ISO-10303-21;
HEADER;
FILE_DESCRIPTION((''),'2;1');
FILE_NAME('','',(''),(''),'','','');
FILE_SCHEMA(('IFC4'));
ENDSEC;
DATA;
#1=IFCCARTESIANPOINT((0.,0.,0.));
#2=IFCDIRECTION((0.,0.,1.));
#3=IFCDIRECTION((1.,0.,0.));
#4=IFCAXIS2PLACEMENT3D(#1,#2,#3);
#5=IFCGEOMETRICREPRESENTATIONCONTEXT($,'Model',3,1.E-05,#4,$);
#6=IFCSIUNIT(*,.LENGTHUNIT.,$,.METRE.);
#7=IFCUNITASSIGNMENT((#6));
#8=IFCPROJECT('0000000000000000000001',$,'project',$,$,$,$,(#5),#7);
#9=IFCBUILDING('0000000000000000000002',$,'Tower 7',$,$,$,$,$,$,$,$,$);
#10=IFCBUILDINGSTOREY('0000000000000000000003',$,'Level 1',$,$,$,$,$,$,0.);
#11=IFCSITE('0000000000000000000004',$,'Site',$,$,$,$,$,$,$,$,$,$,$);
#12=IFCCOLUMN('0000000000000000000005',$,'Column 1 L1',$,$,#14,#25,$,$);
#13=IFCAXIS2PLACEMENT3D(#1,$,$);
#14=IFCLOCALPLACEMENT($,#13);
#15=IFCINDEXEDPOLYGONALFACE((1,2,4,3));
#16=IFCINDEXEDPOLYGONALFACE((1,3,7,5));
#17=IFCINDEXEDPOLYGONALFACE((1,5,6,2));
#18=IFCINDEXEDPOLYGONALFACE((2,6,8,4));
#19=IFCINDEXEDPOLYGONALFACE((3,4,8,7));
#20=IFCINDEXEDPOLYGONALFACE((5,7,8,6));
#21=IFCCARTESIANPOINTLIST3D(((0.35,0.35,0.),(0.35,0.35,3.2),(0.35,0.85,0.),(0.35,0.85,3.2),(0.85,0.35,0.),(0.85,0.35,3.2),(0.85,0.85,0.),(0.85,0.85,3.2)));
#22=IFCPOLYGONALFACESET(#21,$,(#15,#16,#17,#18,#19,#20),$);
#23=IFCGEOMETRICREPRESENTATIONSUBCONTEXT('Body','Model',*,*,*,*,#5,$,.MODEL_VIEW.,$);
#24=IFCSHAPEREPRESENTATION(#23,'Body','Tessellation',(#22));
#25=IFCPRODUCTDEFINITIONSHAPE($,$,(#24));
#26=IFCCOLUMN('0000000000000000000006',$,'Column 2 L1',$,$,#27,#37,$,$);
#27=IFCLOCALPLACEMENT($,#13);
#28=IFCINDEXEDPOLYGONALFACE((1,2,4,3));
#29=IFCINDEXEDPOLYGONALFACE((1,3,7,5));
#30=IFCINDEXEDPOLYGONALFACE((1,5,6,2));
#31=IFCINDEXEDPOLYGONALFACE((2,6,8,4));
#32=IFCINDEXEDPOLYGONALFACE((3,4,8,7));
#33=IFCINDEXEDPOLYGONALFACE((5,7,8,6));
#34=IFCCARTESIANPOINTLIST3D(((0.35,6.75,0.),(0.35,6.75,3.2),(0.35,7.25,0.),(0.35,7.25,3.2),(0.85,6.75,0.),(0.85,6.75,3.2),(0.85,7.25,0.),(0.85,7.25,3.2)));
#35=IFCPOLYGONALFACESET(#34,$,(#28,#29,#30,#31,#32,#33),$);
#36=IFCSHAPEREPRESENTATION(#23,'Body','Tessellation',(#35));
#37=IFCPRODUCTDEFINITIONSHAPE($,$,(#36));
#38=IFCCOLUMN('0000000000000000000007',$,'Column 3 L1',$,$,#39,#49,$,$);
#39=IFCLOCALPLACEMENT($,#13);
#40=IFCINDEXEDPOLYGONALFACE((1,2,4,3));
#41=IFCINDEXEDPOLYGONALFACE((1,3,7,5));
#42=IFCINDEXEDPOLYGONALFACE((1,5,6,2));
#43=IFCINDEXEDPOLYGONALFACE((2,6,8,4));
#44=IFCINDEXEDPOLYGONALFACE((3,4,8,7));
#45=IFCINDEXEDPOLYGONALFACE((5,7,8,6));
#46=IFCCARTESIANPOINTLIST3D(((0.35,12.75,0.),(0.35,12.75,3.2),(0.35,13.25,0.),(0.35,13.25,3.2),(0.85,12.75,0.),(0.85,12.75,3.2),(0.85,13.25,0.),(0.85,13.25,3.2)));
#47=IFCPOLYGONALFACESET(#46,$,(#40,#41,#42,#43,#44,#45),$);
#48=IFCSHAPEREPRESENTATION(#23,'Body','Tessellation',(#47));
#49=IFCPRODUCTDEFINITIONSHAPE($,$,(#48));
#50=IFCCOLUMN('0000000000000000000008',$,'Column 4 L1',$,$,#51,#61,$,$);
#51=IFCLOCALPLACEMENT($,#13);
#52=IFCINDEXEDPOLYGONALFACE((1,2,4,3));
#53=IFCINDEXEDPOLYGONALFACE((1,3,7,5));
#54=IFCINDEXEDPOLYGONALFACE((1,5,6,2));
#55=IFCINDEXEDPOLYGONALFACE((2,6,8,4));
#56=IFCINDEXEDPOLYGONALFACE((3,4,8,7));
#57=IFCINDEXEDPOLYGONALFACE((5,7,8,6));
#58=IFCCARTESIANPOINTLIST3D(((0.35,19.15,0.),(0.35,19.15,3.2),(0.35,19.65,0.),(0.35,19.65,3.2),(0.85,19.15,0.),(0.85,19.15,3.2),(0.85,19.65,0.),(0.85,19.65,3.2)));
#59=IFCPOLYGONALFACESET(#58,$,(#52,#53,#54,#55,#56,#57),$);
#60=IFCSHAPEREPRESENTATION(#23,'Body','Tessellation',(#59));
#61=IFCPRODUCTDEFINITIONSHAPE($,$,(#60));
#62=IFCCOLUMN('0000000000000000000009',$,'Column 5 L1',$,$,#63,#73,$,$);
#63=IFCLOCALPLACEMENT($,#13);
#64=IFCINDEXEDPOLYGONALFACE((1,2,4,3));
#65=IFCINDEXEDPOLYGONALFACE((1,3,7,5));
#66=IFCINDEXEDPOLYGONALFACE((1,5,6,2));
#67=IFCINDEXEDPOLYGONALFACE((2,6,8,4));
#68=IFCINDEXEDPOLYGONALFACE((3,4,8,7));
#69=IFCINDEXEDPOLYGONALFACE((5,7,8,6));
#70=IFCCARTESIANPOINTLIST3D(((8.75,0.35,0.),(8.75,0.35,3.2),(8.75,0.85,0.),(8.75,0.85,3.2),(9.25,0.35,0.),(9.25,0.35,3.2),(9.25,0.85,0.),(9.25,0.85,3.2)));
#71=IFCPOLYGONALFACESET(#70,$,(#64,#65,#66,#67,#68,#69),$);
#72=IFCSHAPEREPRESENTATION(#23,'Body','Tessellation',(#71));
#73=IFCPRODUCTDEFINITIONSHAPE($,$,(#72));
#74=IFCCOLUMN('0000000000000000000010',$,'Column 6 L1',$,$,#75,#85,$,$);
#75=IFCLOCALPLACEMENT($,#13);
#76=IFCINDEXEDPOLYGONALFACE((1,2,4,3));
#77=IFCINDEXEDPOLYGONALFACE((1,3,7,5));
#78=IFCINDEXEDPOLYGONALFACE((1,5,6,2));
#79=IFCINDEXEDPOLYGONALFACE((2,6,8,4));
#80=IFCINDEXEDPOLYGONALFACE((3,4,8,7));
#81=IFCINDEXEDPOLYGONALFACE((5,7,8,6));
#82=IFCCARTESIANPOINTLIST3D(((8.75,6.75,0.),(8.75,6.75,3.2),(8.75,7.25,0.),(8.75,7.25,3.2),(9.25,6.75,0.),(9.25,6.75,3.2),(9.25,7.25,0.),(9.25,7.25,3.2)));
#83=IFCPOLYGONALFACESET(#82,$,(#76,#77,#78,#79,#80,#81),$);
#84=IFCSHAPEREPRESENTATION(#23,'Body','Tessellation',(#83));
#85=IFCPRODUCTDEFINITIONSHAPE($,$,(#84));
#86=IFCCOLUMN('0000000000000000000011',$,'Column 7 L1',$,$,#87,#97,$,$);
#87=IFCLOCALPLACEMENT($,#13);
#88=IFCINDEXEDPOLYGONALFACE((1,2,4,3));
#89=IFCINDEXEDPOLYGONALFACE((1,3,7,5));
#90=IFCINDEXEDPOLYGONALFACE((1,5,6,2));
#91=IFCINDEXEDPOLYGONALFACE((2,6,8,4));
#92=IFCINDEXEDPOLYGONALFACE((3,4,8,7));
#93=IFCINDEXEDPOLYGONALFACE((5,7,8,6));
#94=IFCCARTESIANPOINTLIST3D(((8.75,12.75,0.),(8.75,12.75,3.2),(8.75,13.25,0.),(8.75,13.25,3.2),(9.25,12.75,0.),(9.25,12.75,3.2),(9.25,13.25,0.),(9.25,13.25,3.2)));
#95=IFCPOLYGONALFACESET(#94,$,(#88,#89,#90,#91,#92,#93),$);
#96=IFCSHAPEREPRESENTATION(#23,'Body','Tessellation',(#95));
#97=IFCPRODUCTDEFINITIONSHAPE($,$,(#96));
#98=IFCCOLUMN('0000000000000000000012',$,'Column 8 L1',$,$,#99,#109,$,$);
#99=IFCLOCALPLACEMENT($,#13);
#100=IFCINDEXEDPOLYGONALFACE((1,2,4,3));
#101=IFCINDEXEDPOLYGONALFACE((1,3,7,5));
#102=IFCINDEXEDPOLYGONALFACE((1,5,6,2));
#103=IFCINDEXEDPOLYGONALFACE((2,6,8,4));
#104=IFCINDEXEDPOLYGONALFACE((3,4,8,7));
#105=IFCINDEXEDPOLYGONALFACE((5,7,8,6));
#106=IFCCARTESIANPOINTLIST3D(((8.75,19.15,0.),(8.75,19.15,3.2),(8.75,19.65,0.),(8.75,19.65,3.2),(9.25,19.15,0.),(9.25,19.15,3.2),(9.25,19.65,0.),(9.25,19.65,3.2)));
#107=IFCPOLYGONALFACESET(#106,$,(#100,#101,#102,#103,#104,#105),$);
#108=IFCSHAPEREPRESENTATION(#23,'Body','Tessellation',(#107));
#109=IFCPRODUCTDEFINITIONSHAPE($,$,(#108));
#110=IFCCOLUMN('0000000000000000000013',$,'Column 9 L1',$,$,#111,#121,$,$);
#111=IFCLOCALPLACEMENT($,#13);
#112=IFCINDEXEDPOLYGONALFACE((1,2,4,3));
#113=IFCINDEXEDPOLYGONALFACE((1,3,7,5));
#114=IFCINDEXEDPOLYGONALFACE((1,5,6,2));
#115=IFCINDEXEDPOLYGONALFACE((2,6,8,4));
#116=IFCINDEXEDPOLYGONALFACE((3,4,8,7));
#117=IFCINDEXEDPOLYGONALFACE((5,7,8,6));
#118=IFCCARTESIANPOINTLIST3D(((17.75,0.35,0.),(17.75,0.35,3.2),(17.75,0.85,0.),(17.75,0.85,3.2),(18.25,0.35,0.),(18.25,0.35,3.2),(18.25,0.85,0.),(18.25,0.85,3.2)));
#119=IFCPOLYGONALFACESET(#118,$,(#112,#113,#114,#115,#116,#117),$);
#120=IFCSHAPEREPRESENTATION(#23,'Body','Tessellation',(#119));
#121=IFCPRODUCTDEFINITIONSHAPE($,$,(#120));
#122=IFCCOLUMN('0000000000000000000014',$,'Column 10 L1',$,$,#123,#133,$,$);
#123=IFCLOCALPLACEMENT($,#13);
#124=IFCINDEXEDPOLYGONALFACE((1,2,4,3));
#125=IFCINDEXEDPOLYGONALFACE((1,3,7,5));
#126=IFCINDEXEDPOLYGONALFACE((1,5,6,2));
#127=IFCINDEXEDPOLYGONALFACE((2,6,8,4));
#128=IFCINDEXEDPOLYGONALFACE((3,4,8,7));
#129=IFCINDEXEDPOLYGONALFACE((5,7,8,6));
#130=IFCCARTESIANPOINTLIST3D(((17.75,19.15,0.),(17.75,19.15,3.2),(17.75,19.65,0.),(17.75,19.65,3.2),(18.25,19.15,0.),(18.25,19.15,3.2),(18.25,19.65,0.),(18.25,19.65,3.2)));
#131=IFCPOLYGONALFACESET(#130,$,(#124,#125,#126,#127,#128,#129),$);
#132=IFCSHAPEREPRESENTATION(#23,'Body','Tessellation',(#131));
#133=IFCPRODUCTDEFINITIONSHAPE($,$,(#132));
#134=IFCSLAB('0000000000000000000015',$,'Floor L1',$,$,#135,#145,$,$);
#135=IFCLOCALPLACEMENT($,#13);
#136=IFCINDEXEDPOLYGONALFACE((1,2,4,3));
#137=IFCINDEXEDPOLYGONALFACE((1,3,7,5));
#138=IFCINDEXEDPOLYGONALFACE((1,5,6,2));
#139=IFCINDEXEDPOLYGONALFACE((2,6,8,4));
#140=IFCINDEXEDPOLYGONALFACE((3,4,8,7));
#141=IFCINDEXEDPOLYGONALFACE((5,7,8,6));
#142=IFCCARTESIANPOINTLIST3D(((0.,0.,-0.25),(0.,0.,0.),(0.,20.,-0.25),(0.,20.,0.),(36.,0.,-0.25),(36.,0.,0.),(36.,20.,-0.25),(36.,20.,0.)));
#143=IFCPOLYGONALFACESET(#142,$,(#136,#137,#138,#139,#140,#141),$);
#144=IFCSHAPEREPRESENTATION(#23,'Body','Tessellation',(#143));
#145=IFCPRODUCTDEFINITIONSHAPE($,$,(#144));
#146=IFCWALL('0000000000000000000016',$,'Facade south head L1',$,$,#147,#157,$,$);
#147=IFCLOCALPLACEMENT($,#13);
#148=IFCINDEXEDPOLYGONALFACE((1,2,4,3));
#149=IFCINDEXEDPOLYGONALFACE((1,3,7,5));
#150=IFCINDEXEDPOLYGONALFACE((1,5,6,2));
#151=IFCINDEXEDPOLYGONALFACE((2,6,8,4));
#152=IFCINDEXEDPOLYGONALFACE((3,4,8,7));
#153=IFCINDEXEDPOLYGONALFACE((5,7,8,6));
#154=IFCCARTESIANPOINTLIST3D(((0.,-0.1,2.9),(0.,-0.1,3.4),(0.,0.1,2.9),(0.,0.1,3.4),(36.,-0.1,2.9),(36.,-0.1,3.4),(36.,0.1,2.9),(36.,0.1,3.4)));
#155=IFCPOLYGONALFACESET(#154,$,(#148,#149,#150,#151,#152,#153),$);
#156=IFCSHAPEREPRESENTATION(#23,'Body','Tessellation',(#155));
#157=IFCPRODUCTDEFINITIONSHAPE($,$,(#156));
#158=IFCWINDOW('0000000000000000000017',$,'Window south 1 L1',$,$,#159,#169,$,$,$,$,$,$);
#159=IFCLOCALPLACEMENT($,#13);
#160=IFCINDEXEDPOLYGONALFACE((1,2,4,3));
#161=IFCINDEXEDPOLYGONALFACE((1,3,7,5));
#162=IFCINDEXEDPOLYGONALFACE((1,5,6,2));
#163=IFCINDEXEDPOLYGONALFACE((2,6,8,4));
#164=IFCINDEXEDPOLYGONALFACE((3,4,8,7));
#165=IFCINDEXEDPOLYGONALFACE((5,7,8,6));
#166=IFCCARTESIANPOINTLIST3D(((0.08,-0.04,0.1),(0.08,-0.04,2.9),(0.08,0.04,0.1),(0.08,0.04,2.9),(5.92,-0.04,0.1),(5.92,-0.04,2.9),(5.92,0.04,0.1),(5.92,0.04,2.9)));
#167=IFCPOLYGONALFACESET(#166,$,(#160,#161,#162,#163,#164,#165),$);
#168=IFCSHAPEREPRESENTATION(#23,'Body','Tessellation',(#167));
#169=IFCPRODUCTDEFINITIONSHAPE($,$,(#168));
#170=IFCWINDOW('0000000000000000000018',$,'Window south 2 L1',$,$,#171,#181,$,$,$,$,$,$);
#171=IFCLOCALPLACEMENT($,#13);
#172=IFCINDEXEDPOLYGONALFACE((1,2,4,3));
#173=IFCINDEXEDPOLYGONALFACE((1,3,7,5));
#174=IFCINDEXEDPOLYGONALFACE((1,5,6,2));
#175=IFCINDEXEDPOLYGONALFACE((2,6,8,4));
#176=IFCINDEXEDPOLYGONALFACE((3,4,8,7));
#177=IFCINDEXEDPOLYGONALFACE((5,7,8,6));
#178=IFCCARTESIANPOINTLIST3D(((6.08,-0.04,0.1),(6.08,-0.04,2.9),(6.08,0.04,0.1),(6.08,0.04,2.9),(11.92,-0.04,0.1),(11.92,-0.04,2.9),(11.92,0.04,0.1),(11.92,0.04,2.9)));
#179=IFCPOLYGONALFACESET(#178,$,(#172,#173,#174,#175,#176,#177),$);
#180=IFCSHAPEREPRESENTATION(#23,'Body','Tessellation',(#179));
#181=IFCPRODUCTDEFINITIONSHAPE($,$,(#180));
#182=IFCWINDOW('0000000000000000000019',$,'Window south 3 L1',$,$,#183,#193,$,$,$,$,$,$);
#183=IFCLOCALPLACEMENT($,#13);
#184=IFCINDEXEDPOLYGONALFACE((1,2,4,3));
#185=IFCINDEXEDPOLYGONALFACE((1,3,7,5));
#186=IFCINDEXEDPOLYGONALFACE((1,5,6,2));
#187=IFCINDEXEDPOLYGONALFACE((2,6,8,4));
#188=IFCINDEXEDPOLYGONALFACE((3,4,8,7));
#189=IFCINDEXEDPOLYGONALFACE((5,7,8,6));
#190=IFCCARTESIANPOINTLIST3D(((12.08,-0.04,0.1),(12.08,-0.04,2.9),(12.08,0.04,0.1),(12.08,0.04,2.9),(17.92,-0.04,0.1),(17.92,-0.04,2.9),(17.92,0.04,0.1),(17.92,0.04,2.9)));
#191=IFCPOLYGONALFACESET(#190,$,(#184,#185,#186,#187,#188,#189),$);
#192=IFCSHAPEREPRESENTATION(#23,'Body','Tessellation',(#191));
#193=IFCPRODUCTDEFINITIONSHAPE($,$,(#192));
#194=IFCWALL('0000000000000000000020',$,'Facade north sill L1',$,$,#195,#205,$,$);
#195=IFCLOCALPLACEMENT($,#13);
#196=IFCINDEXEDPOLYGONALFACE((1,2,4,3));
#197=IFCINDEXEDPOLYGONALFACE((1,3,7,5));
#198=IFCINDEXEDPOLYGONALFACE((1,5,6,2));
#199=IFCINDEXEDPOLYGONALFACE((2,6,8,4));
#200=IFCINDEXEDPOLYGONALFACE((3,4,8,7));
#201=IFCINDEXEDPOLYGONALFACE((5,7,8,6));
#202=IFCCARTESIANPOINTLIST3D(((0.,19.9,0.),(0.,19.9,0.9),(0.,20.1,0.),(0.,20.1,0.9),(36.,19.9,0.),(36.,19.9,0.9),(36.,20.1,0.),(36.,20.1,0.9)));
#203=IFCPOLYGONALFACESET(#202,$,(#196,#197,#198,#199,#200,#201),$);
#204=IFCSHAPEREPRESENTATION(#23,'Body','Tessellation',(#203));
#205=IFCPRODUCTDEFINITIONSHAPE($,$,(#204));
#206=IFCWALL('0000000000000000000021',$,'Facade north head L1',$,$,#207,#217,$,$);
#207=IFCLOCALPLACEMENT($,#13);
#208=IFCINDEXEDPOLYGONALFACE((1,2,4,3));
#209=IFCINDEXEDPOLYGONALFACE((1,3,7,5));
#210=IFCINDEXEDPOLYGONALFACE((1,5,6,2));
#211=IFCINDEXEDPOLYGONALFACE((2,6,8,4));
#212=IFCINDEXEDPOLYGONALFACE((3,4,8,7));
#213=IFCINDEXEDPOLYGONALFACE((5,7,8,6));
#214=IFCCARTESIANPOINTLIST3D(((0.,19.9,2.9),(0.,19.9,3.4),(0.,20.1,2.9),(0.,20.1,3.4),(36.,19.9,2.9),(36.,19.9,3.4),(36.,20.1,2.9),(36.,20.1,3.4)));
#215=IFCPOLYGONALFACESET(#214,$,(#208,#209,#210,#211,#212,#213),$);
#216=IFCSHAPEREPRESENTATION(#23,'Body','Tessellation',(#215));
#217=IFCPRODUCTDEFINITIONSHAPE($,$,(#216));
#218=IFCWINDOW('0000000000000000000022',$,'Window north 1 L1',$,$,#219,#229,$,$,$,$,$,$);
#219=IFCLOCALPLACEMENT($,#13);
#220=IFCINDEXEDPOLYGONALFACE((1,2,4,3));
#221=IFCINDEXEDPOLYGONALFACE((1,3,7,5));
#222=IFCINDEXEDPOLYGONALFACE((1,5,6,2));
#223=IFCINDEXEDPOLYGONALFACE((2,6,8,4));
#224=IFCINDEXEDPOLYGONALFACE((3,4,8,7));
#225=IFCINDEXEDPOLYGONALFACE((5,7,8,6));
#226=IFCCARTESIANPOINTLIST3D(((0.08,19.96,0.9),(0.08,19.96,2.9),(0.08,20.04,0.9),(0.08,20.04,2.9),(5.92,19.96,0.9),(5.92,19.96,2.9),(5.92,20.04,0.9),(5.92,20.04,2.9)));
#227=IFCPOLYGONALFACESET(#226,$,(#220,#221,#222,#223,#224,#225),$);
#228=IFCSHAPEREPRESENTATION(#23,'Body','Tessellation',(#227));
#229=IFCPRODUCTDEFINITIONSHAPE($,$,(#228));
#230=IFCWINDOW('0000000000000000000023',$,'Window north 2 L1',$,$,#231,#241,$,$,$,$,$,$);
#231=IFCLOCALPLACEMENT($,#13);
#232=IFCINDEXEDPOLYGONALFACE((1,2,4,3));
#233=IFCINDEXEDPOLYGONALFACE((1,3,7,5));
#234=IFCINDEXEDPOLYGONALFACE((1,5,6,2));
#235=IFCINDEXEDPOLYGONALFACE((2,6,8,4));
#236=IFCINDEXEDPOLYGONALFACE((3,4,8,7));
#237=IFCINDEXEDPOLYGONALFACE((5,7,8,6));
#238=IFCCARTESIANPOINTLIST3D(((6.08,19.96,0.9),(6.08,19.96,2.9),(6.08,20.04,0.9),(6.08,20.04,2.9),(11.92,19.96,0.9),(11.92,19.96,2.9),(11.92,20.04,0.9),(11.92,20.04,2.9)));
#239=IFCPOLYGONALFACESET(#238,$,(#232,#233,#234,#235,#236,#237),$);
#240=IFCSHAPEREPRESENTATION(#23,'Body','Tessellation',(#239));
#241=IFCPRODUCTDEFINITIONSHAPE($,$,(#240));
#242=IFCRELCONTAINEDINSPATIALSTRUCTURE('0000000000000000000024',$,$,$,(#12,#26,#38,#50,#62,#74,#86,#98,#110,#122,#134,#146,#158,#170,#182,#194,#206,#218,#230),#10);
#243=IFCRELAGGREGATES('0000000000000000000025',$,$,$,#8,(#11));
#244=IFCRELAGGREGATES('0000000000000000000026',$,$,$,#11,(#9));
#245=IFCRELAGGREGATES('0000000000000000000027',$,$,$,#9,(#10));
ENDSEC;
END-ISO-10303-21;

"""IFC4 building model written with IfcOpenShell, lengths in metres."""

from ifc_helpers import new_model, si_unit, frame, origin, origin_with_axes, origin_2d, place, context, subcontext, project, spatial, rectangle, extrude, element, save


model = new_model("IFC4")

# Units and contexts
model_context = context("Model", 3, precision=1e-05, world=origin_with_axes())
body_context = subcontext(model_context, "Body", "Model", "MODEL_VIEW")
ifc_project = project(units=[si_unit("LENGTHUNIT", "METRE")], contexts=[model_context])

# Site, building, storey
site = spatial("IfcSite", under=ifc_project, Name="Site")
building = spatial("IfcBuilding", under=site, Name="Tower 7")
storey = spatial("IfcBuildingStorey", under=building, Name="Level 1", Elevation=0.0)

# Columns
for number, where, z_axis, x_axis, name in (
    (1, (0.6, 0.6, 0.0), (0.0, 0.0, 1.0), (1.0, 0.0, 0.0), "Column 1 L1"),
    (2, (0.6, 7.0, 0.0), (0.0, 0.0, 1.0), (1.0, 0.0, 0.0), "Column 2 L1"),
    (3, (0.6, 13.0, 0.0), (0.0, 0.0, 1.0), (1.0, 0.0, 0.0), "Column 3 L1"),
    (4, (0.6, 19.4, 0.0), (0.0, 0.0, 1.0), (1.0, 0.0, 0.0), "Column 4 L1"),
    (5, (9.0, 0.6, 0.0), (0.0, 0.0, 1.0), (1.0, 0.0, 0.0), "Column 5 L1"),
    (6, (9.0, 7.0, 0.0), (0.0, 0.0, 1.0), (1.0, 0.0, 0.0), "Column 6 L1"),
    (7, (9.0, 13.0, 0.0), (0.0, 0.0, 1.0), (1.0, 0.0, 0.0), "Column 7 L1"),
    (8, (9.0, 19.4, 0.0), (0.0, 0.0, 1.0), (1.0, 0.0, 0.0), "Column 8 L1"),
    (9, (18.0, 0.6, 0.0), (0.0, 0.0, 1.0), (1.0, 0.0, 0.0), "Column 9 L1"),
    (10, (18.0, 19.4, 0.0), (0.0, 0.0, 1.0), (1.0, 0.0, 0.0), "Column 10 L1"),
):
    element("IfcColumn", number, at=place(None, frame(where, z_axis=z_axis, x_axis=x_axis)), inside=storey, Name=name, context=body_context, shape_type="SweptSolid", body=[
        extrude(rectangle(XDim=0.5, YDim=0.5, at=origin_2d()), origin(), (0.0, 0.0, 1.0), 3.2),
    ])

# Slab
slab_placement = place(None, frame((18.0, 10.0, -0.25), z_axis=(0.0, 0.0, 1.0), x_axis=(1.0, 0.0, 0.0)))
element("IfcSlab", 11, at=slab_placement, inside=storey, Name="Floor L1", context=body_context, shape_type="SweptSolid", body=[
    extrude(rectangle(XDim=36.0, YDim=20.0, at=origin_2d()), origin(), (0.0, 0.0, 1.0), 0.25),
])

# Wall
wall_1_placement = place(None, frame((18.0, 0.0, 2.9), z_axis=(0.0, 0.0, 1.0), x_axis=(1.0, 0.0, 0.0)))
element("IfcWall", 12, at=wall_1_placement, inside=storey, Name="Facade south head L1", context=body_context, shape_type="SweptSolid", body=[
    extrude(rectangle(XDim=36.0, YDim=0.2, at=origin_2d()), origin(), (0.0, 0.0, 1.0), 0.5),
])

# Windows
for number, where, z_axis, x_axis, name in (
    (13, (3.0, 0.0, 0.1), (0.0, 0.0, 1.0), (1.0, 0.0, 0.0), "Window south 1 L1"),
    (14, (9.0, 0.0, 0.1), (0.0, 0.0, 1.0), (1.0, 0.0, 0.0), "Window south 2 L1"),
):
    element("IfcWindow", number, at=place(None, frame(where, z_axis=z_axis, x_axis=x_axis)), inside=storey, Name=name, context=body_context, shape_type="SweptSolid", body=[
        extrude(rectangle(XDim=5.84, YDim=0.08, at=origin_2d()), origin(), (0.0, 0.0, 1.0), 2.8),
    ])
window_1_placement = place(None, frame((15.0, 0.0, 0.1), z_axis=(0.0, 0.0, 1.0), x_axis=(1.0, 0.0, 0.0)))
element("IfcWindow", 15, at=window_1_placement, inside=storey, Name="Window south 3 L1", context=body_context, shape_type="SweptSolid", body=[
    extrude(rectangle(XDim=5.84, YDim=0.08, at=origin_2d()), origin(), (0.0, 0.0, 1.0), 2.8),
])

# Walls
wall_2_placement = place(None, frame((18.0, 20.0, 0.0), z_axis=(0.0, 0.0, 1.0), x_axis=(1.0, 0.0, 0.0)))
element("IfcWall", 16, at=wall_2_placement, inside=storey, Name="Facade north sill L1", context=body_context, shape_type="SweptSolid", body=[
    extrude(rectangle(XDim=36.0, YDim=0.2, at=origin_2d()), origin(), (0.0, 0.0, 1.0), 0.9),
])
wall_3_placement = place(None, frame((18.0, 20.0, 2.9), z_axis=(0.0, 0.0, 1.0), x_axis=(1.0, 0.0, 0.0)))
element("IfcWall", 17, at=wall_3_placement, inside=storey, Name="Facade north head L1", context=body_context, shape_type="SweptSolid", body=[
    extrude(rectangle(XDim=36.0, YDim=0.2, at=origin_2d()), origin(), (0.0, 0.0, 1.0), 0.5),
])

# Windows
for number, where, z_axis, x_axis, name in (
    (18, (3.0, 20.0, 0.9), (0.0, 0.0, 1.0), (1.0, 0.0, 0.0), "Window north 1 L1"),
    (19, (9.0, 20.0, 0.9), (0.0, 0.0, 1.0), (1.0, 0.0, 0.0), "Window north 2 L1"),
):
    element("IfcWindow", number, at=place(None, frame(where, z_axis=z_axis, x_axis=x_axis)), inside=storey, Name=name, context=body_context, shape_type="SweptSolid", body=[
        extrude(rectangle(XDim=5.84, YDim=0.08, at=origin_2d()), origin(), (0.0, 0.0, 1.0), 2.0),
    ])

save(model, "model.ifc")
